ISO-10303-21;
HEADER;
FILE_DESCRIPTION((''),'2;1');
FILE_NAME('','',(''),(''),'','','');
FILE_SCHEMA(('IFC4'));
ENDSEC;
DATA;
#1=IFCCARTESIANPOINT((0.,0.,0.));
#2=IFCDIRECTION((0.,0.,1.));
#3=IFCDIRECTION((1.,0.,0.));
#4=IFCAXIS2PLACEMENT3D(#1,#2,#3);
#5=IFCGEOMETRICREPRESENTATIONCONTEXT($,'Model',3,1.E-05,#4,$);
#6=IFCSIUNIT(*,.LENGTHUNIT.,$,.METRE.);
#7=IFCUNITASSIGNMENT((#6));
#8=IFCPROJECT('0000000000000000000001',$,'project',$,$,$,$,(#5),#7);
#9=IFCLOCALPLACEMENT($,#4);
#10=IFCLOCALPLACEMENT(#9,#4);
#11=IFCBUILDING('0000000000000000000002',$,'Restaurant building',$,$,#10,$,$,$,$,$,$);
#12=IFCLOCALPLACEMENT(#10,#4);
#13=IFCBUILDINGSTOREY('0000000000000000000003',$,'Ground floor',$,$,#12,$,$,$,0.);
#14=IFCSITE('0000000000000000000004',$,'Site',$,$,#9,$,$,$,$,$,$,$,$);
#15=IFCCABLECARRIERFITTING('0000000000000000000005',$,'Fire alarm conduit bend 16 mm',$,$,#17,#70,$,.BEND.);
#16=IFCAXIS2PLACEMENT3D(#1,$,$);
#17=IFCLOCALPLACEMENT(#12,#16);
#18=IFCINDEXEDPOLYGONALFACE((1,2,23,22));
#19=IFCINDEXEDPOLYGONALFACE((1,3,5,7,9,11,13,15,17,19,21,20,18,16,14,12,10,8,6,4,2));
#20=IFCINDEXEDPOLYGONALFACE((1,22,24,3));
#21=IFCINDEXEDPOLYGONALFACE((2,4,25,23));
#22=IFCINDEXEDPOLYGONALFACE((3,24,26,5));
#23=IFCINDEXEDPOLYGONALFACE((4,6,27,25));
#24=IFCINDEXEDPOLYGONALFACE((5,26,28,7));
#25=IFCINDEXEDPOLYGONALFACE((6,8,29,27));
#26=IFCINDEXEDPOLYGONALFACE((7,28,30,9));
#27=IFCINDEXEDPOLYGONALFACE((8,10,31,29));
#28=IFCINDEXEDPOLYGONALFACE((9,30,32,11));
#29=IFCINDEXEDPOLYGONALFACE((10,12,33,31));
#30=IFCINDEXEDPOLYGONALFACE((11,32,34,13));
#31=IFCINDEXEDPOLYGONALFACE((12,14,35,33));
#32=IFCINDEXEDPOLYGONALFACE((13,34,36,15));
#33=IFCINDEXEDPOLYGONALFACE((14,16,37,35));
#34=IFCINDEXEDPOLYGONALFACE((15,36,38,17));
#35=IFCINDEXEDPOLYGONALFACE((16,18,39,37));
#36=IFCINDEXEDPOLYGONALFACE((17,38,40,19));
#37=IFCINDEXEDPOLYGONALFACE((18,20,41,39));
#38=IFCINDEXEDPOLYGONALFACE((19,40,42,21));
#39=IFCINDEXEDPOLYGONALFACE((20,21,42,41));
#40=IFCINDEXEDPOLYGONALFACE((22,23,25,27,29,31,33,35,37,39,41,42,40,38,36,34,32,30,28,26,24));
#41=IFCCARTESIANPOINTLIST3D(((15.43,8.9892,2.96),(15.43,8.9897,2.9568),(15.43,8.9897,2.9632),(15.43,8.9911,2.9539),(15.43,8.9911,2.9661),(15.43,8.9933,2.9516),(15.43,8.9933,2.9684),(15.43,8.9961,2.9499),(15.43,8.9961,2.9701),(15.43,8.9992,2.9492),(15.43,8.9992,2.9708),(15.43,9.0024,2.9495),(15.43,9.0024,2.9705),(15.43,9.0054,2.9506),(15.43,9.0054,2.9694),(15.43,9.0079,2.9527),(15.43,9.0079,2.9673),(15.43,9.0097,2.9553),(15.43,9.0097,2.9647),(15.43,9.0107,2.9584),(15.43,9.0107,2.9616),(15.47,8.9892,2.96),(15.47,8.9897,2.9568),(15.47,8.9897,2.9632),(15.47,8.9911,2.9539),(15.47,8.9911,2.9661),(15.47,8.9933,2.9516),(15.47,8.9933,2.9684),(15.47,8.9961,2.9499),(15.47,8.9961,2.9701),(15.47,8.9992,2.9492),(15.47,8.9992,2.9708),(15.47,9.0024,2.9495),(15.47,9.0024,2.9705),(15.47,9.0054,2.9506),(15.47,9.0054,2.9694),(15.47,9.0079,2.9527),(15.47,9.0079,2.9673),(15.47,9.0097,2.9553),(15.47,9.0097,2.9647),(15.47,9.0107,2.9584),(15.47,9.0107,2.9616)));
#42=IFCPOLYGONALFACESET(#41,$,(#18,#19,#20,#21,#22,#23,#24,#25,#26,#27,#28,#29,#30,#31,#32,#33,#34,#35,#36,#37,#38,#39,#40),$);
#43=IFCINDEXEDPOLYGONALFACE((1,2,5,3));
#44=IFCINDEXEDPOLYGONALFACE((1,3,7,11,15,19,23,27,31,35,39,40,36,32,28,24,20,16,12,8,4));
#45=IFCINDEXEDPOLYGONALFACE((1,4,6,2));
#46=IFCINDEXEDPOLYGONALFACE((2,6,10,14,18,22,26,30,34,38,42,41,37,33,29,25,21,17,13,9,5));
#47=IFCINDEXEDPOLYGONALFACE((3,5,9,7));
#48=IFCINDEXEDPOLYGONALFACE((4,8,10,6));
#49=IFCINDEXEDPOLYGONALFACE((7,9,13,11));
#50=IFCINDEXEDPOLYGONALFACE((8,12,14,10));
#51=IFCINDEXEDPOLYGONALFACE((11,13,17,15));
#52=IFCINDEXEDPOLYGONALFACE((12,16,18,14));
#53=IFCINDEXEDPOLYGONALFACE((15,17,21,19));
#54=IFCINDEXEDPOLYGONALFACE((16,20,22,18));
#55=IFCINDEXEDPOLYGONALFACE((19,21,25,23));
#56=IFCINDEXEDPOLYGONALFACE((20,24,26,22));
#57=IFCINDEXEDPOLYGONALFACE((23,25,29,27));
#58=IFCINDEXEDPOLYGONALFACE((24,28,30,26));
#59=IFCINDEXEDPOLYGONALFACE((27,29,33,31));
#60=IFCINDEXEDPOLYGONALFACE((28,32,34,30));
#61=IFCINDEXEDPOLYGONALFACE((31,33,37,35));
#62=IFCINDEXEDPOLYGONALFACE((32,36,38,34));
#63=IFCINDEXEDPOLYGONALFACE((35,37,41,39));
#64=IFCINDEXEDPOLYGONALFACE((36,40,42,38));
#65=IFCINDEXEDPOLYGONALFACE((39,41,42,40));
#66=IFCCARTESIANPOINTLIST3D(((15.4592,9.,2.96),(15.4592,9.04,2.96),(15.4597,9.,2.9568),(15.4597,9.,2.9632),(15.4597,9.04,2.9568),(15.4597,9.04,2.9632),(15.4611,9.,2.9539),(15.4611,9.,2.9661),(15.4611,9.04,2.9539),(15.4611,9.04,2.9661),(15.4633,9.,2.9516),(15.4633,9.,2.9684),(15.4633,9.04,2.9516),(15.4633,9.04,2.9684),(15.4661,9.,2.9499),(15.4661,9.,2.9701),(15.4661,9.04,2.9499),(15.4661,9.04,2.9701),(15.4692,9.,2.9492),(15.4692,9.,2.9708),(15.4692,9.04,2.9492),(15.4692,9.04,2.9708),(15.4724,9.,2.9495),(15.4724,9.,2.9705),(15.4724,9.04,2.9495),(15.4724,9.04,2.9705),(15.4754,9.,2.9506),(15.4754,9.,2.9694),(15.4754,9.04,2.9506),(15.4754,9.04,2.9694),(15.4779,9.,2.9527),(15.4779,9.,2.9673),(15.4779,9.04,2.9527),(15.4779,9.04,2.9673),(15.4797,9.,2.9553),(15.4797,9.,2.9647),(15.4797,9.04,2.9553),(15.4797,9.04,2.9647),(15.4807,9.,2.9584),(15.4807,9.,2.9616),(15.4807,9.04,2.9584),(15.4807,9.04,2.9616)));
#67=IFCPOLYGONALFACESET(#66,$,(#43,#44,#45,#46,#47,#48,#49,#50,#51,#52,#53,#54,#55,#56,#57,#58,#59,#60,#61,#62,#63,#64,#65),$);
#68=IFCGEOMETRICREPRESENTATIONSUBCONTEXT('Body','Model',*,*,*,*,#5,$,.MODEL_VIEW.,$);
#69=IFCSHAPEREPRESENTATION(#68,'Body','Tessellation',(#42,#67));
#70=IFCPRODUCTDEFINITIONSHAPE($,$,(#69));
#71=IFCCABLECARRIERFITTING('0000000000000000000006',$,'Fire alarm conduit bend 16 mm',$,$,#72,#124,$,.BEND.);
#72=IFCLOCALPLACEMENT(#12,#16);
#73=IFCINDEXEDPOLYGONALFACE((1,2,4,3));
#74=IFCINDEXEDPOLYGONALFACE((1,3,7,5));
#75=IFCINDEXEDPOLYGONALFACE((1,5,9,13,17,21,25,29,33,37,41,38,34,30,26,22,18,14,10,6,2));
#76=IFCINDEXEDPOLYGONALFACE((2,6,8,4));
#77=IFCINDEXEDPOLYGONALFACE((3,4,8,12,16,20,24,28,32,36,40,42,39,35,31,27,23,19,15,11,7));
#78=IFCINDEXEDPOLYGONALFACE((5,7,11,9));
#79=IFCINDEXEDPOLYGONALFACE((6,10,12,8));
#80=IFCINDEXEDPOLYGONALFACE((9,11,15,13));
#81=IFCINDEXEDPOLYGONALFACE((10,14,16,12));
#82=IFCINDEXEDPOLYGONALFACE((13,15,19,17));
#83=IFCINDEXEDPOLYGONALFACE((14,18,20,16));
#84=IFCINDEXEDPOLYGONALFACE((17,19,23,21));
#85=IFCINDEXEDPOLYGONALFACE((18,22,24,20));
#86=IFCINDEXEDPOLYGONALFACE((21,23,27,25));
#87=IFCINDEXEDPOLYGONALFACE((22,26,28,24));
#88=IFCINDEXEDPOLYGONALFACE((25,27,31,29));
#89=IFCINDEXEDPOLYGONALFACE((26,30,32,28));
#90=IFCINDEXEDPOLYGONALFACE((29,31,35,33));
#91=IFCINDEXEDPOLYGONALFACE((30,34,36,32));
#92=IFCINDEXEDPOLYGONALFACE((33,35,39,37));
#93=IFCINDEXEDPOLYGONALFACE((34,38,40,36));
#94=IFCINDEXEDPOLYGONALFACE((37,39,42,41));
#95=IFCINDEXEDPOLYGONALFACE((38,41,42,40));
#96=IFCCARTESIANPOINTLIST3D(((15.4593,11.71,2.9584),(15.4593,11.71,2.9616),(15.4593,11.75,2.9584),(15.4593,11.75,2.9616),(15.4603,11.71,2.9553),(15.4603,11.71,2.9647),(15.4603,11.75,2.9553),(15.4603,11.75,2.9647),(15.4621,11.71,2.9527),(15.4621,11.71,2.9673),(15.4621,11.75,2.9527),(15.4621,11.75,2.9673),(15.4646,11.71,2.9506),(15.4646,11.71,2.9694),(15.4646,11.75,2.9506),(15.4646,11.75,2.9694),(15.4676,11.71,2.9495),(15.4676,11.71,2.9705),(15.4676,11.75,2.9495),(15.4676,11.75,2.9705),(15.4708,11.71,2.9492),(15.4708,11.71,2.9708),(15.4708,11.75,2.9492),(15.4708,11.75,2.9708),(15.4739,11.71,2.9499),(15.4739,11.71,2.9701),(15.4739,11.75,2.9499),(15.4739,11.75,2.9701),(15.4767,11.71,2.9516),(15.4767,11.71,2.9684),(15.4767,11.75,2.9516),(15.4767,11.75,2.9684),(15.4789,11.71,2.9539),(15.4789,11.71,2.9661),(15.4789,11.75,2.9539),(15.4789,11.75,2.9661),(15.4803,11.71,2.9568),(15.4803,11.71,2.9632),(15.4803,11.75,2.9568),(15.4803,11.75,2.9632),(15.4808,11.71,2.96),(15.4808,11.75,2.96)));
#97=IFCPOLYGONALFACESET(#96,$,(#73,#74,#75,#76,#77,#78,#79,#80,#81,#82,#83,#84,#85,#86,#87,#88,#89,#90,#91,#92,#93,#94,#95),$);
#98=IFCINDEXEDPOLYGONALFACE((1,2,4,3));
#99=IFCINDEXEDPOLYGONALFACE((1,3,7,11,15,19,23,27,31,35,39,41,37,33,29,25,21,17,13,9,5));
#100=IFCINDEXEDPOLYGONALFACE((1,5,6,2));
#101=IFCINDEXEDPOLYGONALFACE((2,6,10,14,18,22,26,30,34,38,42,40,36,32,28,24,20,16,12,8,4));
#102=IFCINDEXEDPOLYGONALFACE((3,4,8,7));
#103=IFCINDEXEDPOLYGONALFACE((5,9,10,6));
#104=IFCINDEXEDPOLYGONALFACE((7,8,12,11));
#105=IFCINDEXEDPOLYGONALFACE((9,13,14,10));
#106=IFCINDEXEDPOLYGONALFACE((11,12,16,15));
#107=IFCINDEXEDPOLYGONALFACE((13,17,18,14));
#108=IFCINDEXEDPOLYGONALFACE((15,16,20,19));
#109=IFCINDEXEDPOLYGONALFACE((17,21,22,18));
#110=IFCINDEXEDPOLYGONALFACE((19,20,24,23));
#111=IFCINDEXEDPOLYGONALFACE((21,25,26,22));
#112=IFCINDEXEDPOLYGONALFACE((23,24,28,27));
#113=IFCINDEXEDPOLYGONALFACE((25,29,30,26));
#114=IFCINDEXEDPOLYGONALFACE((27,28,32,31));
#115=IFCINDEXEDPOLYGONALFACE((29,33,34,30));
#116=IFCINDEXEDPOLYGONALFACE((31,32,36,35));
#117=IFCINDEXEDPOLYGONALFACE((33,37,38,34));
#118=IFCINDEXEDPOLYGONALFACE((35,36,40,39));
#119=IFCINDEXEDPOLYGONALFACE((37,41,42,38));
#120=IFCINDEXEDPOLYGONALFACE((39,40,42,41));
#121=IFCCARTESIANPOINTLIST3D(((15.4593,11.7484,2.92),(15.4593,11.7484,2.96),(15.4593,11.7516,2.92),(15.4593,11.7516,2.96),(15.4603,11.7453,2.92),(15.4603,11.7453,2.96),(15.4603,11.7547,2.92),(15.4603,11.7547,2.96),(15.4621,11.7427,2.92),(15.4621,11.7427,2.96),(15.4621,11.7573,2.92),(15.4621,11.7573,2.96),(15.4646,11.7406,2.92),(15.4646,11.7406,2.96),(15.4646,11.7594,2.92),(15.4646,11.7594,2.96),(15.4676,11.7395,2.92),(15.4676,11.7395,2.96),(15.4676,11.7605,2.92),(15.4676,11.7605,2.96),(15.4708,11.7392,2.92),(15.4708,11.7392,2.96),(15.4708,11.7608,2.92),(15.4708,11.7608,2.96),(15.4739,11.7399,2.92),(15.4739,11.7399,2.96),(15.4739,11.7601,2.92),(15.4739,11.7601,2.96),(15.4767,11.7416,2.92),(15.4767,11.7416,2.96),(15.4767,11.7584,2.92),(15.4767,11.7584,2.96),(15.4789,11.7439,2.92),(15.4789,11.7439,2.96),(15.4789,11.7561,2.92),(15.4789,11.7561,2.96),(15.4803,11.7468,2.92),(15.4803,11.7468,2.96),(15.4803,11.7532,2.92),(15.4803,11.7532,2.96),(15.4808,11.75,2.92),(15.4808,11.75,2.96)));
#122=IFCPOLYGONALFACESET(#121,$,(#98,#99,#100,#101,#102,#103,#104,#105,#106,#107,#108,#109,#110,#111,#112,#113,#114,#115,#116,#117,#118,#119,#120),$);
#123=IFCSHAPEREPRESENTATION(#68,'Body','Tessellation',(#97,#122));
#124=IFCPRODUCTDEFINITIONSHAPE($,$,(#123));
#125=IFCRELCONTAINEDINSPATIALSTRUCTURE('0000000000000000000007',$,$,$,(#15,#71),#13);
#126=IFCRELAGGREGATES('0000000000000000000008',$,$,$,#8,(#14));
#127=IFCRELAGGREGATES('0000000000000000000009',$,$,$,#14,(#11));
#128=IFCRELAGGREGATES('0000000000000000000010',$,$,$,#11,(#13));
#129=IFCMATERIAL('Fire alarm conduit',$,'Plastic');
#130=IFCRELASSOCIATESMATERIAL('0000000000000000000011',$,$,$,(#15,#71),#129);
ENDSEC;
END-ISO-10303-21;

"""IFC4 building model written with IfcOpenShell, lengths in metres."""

from ifc_helpers import new_model, si_unit, frame, origin_with_axes, origin_2d, place, context, subcontext, project, spatial, circle, extrude, material, element, save


model = new_model("IFC4")

# Units and contexts
model_context = context("Model", 3, precision=1e-05, world=origin_with_axes())
body_context = subcontext(model_context, "Body", "Model", "MODEL_VIEW")
ifc_project = project(units=[si_unit("LENGTHUNIT", "METRE")], contexts=[model_context])

# Site, building, storey
site_placement = place(None, origin_with_axes())
site = spatial("IfcSite", under=ifc_project, at=site_placement, Name="Site")
building_placement = place(site_placement, origin_with_axes())
building = spatial("IfcBuilding", under=site, at=building_placement, Name="Restaurant building")
storey_placement = place(building_placement, origin_with_axes())
storey = spatial("IfcBuildingStorey", under=building, at=storey_placement, Name="Ground floor", Elevation=0.0)

# Shared definitions
ifc_material_1 = material(Name="Fire alarm conduit", Category="Plastic")

# Cable carrier fittings
cable_carrier_fitting_1_placement = place(storey_placement, frame((15.47, 9.0, 2.96)))
element("IfcCableCarrierFitting", 1, at=cable_carrier_fitting_1_placement, inside=storey, material=ifc_material_1, Name="Fire alarm conduit bend 16 mm", PredefinedType="BEND", context=body_context, shape_type="SweptSolid", body=[
    extrude(circle(Radius=0.0108, at=origin_2d()), frame((0.0, 0.0, 0.0), z_axis=(-1.0, 0.0, 0.0), x_axis=(0.0, -1.0, 0.0)), (0.0, 0.0, 1.0), 0.04),
    extrude(circle(Radius=0.0108, at=origin_2d()), frame((0.0, 0.0, 0.0), z_axis=(0.0, 1.0, 0.0), x_axis=(-1.0, 0.0, 0.0)), (0.0, 0.0, 1.0), 0.04),
])
cable_carrier_fitting_2_placement = place(storey_placement, frame((15.47, 11.75, 2.96)))
element("IfcCableCarrierFitting", 2, at=cable_carrier_fitting_2_placement, inside=storey, material=ifc_material_1, Name="Fire alarm conduit bend 16 mm", PredefinedType="BEND", context=body_context, shape_type="SweptSolid", body=[
    extrude(circle(Radius=0.0108, at=origin_2d()), frame((0.0, 0.0, 0.0), z_axis=(0.0, -1.0, 0.0), x_axis=(1.0, 0.0, 0.0)), (0.0, 0.0, 1.0), 0.04),
    extrude(circle(Radius=0.0108, at=origin_2d()), frame((0.0, 0.0, 0.0), z_axis=(0.0, 0.0, -1.0), x_axis=(1.0, 0.0, 0.0)), (0.0, 0.0, 1.0), 0.04),
])

save(model, "model.ifc")
